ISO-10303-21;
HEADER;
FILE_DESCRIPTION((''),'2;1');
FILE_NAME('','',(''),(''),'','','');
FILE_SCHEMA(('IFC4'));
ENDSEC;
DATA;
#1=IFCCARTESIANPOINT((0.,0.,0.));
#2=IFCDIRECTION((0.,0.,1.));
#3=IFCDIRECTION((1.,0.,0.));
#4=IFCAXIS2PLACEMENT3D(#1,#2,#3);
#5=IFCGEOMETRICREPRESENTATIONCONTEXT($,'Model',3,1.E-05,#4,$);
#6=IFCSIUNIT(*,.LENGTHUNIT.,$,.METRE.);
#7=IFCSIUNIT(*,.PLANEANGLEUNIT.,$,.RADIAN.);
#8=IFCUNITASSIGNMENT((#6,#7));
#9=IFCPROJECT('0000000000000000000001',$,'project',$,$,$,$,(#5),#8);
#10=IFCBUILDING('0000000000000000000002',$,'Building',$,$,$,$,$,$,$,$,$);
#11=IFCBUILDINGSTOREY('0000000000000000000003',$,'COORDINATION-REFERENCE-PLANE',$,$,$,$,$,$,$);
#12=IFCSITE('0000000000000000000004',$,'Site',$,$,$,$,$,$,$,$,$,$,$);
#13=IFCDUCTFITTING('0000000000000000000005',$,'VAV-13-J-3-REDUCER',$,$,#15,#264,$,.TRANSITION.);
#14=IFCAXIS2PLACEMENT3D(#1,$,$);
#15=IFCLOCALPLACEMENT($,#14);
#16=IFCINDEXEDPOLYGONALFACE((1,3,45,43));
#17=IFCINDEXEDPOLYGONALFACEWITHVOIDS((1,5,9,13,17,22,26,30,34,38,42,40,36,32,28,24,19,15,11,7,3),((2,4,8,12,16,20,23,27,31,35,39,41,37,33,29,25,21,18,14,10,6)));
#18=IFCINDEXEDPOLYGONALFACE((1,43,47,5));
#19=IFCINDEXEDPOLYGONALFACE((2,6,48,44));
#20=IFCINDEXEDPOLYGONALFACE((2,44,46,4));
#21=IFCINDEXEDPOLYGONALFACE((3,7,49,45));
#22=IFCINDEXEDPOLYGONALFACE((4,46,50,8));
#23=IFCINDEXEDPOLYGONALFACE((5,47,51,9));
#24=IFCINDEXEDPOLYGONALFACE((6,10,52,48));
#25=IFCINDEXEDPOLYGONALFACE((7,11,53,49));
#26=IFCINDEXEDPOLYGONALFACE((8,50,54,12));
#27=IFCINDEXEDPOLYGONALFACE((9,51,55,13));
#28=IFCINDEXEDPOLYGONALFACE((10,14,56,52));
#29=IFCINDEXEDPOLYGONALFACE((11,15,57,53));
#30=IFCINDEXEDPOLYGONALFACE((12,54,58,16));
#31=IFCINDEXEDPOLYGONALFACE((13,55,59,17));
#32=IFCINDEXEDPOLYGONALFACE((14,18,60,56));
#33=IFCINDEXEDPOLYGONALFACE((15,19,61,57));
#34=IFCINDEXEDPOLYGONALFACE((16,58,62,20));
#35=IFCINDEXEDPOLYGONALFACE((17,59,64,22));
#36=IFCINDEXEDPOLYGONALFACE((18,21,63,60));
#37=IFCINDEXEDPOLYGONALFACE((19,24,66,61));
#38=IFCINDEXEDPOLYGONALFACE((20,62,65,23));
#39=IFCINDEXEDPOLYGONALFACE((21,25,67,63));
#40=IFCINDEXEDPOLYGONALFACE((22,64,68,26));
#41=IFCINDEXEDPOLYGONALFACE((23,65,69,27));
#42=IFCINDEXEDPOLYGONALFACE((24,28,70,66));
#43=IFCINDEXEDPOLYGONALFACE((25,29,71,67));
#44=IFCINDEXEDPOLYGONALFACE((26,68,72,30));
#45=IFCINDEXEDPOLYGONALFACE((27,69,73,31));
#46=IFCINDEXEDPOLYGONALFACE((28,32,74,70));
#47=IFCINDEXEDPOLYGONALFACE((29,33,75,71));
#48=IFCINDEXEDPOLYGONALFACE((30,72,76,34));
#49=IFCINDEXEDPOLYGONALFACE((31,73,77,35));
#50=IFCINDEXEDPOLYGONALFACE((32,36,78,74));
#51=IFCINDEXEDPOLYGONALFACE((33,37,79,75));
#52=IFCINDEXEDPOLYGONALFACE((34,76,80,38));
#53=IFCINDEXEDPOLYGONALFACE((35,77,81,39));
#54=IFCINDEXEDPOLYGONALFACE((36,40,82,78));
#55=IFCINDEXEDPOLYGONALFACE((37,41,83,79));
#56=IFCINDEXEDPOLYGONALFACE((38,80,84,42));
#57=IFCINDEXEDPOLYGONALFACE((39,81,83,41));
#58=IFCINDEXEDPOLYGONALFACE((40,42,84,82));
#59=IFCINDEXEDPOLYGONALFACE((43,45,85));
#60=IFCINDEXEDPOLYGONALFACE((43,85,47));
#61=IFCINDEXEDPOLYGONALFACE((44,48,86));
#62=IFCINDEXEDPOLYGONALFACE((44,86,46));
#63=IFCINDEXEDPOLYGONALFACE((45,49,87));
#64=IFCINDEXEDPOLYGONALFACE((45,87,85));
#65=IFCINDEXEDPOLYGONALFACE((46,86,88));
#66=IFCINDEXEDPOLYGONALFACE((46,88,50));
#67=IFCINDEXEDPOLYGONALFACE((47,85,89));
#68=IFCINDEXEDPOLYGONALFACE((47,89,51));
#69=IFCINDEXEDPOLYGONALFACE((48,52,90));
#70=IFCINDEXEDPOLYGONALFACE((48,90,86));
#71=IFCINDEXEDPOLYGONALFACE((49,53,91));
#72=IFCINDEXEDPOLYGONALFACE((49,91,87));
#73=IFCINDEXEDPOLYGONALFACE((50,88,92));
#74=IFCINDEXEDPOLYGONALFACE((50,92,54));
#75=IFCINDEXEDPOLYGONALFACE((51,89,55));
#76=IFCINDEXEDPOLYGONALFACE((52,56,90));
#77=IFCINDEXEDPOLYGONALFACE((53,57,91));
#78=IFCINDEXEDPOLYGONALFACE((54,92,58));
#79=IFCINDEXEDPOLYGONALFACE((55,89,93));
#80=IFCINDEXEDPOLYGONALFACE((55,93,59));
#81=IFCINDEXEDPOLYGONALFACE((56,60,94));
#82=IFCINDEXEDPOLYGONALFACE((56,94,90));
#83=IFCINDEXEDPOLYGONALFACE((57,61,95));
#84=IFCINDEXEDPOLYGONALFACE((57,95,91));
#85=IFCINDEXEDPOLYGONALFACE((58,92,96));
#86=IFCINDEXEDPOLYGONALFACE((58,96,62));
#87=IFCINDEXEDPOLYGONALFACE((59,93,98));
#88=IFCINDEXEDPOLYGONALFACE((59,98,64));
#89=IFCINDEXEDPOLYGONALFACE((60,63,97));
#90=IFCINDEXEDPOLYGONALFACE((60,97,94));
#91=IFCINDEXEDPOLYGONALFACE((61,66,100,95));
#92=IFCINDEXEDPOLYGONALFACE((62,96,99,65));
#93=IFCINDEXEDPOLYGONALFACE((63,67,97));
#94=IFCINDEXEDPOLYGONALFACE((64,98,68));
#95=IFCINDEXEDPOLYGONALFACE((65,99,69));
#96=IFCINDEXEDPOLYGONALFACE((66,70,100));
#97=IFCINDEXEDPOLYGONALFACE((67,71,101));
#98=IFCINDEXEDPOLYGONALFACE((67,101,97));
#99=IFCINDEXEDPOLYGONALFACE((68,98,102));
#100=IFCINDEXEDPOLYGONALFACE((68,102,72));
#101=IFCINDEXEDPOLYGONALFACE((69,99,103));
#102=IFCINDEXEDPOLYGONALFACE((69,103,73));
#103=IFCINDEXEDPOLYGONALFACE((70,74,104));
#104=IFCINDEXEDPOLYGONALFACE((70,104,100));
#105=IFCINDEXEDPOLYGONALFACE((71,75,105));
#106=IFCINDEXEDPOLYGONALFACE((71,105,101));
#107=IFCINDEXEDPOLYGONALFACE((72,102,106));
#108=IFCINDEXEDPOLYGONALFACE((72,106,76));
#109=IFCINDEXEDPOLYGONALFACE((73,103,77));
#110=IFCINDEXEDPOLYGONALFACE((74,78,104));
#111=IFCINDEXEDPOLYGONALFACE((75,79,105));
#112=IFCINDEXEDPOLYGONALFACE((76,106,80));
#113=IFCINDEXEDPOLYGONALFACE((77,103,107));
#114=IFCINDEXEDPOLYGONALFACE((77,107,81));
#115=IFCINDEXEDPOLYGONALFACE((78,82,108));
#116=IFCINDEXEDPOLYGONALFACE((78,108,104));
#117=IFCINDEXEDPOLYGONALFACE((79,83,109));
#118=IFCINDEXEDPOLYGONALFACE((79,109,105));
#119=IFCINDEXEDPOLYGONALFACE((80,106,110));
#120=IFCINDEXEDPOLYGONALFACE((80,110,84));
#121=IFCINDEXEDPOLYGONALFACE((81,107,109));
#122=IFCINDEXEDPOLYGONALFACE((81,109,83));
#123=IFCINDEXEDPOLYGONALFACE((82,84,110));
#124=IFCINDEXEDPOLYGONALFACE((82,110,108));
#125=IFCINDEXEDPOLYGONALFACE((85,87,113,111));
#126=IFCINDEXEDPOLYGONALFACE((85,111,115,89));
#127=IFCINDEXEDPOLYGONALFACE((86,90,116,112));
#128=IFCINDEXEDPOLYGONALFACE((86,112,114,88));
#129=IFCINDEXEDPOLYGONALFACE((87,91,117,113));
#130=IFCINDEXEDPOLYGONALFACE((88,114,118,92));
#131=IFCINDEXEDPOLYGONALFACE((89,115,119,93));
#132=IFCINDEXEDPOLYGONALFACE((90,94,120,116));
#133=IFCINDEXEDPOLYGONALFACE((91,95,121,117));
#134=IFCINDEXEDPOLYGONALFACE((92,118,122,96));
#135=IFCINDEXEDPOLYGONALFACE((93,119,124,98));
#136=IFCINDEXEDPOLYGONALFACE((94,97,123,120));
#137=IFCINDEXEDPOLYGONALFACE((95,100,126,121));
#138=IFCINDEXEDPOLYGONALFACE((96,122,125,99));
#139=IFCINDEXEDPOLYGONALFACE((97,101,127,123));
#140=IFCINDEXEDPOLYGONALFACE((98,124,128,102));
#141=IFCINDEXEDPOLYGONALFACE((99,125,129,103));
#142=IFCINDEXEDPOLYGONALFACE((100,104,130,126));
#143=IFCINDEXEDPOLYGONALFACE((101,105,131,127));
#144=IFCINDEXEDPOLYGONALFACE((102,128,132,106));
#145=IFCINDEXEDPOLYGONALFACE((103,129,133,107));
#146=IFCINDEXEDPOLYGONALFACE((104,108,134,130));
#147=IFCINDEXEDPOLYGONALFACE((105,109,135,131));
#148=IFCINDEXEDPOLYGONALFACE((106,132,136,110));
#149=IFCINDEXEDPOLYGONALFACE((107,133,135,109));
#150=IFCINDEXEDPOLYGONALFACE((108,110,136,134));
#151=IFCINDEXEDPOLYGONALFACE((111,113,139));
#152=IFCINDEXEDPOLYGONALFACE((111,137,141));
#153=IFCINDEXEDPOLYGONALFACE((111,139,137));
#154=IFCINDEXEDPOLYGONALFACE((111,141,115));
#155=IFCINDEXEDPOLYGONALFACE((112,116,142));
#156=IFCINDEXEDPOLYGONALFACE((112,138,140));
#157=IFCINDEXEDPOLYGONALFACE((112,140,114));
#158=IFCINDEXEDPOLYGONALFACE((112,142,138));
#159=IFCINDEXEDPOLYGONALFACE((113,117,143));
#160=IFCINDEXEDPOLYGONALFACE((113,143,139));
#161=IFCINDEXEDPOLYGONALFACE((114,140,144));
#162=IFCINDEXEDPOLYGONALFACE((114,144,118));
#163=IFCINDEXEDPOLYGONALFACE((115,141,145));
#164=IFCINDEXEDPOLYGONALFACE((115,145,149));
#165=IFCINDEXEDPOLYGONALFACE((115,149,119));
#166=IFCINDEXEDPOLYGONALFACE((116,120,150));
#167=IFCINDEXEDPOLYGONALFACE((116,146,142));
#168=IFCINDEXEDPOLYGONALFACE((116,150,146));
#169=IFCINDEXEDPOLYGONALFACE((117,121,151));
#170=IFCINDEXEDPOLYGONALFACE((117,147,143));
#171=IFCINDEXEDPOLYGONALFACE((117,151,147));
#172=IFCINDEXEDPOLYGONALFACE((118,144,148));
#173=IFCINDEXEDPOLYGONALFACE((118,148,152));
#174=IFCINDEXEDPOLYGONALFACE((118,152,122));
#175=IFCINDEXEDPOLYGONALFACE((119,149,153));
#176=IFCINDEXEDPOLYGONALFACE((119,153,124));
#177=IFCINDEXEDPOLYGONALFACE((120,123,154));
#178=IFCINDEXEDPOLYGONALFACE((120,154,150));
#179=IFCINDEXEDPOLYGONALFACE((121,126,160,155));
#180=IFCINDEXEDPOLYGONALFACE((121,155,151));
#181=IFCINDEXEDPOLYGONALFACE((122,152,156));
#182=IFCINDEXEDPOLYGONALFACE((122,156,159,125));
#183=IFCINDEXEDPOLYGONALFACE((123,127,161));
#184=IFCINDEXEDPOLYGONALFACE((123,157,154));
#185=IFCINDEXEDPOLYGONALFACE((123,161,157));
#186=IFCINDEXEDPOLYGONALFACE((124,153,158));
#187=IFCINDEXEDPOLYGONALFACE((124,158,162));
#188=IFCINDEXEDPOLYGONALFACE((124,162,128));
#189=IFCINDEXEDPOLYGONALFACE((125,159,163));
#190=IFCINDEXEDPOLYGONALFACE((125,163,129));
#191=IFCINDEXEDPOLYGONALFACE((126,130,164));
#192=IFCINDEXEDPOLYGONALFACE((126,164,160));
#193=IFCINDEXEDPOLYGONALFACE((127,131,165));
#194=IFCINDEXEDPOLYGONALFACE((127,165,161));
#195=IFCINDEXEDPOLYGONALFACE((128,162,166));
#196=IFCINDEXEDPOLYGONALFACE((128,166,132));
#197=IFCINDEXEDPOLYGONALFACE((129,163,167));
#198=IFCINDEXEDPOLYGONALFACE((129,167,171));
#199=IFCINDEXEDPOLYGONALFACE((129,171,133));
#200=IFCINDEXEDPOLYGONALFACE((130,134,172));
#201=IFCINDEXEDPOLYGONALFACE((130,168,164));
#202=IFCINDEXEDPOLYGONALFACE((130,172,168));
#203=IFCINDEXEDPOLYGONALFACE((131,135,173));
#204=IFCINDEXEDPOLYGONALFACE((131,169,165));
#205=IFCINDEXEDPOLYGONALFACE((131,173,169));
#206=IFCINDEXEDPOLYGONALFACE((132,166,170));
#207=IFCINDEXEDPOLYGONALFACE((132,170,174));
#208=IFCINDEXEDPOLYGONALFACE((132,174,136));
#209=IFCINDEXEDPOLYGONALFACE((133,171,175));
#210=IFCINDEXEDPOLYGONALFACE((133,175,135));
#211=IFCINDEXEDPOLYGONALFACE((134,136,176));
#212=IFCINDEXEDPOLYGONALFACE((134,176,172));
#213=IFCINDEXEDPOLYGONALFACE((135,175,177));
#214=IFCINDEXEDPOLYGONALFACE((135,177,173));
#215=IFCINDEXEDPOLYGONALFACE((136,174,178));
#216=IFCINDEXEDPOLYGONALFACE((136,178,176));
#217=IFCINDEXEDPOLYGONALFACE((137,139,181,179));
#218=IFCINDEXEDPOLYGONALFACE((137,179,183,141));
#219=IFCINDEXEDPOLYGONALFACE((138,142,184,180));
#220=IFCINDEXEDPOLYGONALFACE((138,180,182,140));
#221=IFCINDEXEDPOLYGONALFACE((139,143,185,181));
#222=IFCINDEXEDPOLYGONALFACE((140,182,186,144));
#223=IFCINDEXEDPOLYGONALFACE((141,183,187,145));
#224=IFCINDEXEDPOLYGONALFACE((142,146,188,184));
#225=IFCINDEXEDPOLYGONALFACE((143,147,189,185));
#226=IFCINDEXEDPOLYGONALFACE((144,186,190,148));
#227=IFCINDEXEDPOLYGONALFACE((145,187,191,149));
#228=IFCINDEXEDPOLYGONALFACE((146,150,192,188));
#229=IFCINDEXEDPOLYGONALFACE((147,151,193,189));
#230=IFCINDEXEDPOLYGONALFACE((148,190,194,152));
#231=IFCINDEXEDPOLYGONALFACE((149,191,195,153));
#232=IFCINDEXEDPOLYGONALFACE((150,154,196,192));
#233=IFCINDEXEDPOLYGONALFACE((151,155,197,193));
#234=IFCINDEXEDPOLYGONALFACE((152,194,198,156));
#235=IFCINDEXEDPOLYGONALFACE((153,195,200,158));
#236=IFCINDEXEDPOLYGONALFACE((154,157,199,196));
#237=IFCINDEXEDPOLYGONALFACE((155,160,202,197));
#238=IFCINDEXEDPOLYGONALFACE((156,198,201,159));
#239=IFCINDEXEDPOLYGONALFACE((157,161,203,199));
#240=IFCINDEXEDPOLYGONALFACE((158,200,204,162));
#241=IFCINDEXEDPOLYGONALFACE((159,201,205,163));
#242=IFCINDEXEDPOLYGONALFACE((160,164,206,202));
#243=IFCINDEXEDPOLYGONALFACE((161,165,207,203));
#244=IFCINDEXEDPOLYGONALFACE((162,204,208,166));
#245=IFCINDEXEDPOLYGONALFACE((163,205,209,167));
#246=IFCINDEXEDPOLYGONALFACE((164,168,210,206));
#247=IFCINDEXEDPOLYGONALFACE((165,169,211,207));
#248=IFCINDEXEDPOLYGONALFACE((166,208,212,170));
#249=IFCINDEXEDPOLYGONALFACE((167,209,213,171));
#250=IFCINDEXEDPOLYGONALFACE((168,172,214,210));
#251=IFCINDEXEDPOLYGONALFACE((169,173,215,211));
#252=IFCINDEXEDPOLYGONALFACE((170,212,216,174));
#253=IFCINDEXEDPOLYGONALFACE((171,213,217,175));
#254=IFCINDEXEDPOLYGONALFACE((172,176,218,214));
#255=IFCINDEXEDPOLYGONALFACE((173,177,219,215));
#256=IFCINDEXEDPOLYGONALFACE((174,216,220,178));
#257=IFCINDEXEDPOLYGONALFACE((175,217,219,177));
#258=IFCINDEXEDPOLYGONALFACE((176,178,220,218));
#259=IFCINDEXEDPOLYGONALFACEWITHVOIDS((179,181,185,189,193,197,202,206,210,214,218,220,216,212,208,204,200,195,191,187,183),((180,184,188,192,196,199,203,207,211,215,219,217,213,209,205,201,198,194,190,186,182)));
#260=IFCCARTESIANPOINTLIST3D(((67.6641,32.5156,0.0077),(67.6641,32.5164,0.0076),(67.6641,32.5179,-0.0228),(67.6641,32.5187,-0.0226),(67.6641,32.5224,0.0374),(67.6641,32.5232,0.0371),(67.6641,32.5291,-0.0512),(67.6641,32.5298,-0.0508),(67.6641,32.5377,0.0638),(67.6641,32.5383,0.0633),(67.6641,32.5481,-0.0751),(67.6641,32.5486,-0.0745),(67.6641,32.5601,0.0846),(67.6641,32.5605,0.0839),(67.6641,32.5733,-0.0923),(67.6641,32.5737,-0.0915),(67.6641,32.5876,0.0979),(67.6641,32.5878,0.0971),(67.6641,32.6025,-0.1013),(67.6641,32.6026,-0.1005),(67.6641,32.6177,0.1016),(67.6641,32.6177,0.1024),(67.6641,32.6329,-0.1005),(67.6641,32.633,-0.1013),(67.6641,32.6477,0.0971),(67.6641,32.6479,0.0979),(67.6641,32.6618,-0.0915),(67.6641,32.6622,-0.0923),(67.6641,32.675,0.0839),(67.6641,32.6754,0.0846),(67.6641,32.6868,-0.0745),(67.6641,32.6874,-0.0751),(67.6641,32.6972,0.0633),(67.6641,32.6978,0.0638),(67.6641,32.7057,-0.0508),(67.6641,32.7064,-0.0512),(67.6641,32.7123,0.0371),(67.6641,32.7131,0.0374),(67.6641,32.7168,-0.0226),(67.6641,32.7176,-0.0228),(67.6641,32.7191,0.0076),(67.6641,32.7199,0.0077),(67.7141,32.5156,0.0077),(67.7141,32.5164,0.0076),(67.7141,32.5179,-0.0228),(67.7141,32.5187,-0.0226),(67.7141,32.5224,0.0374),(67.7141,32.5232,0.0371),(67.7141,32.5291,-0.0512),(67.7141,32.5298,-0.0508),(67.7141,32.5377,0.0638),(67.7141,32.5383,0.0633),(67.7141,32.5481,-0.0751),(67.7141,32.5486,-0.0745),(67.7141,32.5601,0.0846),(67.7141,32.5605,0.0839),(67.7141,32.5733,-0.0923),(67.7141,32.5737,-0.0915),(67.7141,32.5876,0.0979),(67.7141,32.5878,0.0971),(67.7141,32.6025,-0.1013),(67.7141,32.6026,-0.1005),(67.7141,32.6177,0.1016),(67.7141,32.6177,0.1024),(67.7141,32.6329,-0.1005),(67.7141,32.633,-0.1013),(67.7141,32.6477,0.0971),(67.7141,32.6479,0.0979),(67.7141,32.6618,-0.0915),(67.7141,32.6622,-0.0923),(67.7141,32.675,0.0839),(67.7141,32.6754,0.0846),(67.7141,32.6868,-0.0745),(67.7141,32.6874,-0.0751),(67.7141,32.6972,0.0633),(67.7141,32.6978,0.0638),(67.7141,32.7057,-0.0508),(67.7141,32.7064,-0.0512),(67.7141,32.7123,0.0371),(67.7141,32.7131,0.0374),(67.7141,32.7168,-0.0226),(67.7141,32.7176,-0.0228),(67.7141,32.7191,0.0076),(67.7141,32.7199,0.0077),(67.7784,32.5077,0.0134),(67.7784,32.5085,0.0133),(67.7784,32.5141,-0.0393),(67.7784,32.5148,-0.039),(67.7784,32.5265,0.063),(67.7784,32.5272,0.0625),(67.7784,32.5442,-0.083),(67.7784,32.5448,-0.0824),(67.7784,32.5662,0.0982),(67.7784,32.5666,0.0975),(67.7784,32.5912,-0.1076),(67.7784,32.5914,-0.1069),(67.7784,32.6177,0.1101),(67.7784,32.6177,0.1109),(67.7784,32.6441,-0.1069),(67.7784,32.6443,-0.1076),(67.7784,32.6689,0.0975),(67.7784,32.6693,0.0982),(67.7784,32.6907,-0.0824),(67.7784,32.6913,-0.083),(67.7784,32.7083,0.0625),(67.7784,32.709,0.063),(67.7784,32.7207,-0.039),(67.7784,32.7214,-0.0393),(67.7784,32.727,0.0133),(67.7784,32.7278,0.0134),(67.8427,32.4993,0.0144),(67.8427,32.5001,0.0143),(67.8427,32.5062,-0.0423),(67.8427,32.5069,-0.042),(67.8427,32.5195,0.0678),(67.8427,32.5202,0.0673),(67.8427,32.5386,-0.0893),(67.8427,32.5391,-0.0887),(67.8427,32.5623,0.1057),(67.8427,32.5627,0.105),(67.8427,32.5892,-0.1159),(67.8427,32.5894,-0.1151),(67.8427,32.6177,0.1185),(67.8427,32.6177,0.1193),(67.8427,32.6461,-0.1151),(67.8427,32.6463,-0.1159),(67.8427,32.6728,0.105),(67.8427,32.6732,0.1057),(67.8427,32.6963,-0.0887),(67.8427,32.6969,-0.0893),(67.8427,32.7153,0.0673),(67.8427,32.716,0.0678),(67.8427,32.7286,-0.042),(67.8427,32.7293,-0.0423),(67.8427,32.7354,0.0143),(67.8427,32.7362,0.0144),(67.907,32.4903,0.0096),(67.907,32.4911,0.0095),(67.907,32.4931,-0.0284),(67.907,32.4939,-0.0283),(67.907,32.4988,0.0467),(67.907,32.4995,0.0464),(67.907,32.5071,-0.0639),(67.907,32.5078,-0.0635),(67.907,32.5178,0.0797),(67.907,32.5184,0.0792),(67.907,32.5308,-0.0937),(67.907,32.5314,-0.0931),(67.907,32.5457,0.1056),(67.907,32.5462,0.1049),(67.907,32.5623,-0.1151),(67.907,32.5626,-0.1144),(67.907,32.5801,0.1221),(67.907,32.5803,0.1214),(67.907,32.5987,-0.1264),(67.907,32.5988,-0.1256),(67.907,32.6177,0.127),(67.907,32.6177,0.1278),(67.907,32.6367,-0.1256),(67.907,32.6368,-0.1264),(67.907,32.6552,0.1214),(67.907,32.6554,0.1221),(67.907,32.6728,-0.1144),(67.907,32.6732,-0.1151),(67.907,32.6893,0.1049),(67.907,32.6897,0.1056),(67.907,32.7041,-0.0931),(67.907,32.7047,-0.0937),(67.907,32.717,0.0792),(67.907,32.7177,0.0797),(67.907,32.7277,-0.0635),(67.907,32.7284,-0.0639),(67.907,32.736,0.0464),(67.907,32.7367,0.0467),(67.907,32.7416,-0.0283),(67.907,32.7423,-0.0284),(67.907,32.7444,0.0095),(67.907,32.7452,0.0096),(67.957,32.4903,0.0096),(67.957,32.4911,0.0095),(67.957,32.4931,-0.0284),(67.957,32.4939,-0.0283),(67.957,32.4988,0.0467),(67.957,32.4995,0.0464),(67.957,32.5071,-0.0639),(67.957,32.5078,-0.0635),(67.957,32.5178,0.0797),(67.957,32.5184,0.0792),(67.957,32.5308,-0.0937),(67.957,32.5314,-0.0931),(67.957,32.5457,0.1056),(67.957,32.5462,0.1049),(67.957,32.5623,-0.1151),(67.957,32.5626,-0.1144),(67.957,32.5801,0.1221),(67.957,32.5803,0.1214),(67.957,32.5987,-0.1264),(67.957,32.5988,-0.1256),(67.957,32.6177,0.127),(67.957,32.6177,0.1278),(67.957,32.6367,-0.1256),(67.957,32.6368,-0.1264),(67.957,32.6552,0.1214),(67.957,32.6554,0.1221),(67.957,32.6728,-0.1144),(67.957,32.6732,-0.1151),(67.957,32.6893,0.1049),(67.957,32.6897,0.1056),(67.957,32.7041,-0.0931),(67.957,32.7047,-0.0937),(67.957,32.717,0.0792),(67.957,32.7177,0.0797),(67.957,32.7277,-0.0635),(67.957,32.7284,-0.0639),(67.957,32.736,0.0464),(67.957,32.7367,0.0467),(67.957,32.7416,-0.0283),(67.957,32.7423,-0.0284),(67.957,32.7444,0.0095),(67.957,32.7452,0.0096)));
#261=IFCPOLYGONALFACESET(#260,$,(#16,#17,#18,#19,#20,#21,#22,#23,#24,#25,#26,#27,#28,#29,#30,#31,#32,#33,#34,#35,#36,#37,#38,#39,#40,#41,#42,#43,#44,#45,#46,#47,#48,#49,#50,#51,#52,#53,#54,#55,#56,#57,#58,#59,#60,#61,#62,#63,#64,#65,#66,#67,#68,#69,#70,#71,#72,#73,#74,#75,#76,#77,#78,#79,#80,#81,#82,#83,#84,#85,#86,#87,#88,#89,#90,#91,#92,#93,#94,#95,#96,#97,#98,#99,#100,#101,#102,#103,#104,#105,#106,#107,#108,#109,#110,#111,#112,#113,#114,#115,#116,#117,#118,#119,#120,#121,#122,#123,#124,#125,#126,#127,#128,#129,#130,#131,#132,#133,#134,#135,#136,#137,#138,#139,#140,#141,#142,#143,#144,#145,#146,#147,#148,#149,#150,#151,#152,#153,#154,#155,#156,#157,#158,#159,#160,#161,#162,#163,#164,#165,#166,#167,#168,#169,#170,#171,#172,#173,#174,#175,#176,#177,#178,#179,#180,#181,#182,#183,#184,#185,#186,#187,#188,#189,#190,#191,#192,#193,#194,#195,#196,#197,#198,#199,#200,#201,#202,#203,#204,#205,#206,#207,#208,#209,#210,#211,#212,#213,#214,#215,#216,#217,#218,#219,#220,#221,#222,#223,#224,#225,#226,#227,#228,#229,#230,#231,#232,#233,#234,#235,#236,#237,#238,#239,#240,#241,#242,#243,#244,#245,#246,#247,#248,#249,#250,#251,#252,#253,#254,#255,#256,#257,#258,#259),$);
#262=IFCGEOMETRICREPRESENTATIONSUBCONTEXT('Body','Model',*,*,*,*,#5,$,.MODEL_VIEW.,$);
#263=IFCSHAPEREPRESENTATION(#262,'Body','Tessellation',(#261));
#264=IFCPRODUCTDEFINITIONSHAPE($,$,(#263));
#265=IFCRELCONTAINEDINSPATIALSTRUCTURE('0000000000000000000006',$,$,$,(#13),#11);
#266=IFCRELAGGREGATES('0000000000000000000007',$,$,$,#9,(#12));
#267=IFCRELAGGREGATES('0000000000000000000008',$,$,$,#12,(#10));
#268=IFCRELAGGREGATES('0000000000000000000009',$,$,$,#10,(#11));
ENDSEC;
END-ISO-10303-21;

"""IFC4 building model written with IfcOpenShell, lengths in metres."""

from ifc_helpers import new_model, entity, si_unit, frame, origin_with_axes, place, context, subcontext, project, spatial, element, save


model = new_model("IFC4")

# Units and contexts
model_context = context("Model", 3, precision=1e-05, world=origin_with_axes())
body_context_1 = subcontext(model_context, "Body", "Model", "MODEL_VIEW")
ifc_project = project(units=[si_unit("LENGTHUNIT", "METRE"), si_unit("PLANEANGLEUNIT", "RADIAN")], contexts=[model_context])

# Site, building, storey
site = spatial("IfcSite", under=ifc_project, Name="Site")
building = spatial("IfcBuilding", under=site, Name="Building")
storey = spatial("IfcBuildingStorey", under=building, Name="COORDINATION-REFERENCE-PLANE")

# Duct fitting
for number, where, z_axis, x_axis, name in (
    (1, (67.957, 32.6177, 0.0), (0.0, -1.0, 0.0), (0.0, 0.0, 1.0), "VAV-13-J-3-REDUCER"),
):
    element("IfcDuctFitting", number, at=place(None, frame(where, z_axis=z_axis, x_axis=x_axis)), inside=storey, Name=name, PredefinedType="TRANSITION", context=body_context_1, shape_type="SweptSolid", body=[
        entity("IfcRevolvedAreaSolid", entity("IfcArbitraryClosedProfileDef", "AREA", None, entity("IfcPolyline", [entity("IfcCartesianPoint", [0.1278, 0.0]), entity("IfcCartesianPoint", [0.1278, 0.05]), entity("IfcCartesianPoint", [0.1024, 0.2429]), entity("IfcCartesianPoint", [0.1024, 0.2929]), entity("IfcCartesianPoint", [0.1016, 0.2929]), entity("IfcCartesianPoint", [0.1016, 0.2429]), entity("IfcCartesianPoint", [0.127, 0.05]), entity("IfcCartesianPoint", [0.127, 0.0]), entity("IfcCartesianPoint", [0.1278, 0.0])])), entity("IfcAxis2Placement3D", entity("IfcCartesianPoint", [0.0, 0.0, 0.0])), entity("IfcAxis1Placement", entity("IfcCartesianPoint", [0.0, 0.0, 0.0]), entity("IfcDirection", [0.0, 1.0, 0.0])), 6.283185),
    ])

save(model, "model.ifc")
